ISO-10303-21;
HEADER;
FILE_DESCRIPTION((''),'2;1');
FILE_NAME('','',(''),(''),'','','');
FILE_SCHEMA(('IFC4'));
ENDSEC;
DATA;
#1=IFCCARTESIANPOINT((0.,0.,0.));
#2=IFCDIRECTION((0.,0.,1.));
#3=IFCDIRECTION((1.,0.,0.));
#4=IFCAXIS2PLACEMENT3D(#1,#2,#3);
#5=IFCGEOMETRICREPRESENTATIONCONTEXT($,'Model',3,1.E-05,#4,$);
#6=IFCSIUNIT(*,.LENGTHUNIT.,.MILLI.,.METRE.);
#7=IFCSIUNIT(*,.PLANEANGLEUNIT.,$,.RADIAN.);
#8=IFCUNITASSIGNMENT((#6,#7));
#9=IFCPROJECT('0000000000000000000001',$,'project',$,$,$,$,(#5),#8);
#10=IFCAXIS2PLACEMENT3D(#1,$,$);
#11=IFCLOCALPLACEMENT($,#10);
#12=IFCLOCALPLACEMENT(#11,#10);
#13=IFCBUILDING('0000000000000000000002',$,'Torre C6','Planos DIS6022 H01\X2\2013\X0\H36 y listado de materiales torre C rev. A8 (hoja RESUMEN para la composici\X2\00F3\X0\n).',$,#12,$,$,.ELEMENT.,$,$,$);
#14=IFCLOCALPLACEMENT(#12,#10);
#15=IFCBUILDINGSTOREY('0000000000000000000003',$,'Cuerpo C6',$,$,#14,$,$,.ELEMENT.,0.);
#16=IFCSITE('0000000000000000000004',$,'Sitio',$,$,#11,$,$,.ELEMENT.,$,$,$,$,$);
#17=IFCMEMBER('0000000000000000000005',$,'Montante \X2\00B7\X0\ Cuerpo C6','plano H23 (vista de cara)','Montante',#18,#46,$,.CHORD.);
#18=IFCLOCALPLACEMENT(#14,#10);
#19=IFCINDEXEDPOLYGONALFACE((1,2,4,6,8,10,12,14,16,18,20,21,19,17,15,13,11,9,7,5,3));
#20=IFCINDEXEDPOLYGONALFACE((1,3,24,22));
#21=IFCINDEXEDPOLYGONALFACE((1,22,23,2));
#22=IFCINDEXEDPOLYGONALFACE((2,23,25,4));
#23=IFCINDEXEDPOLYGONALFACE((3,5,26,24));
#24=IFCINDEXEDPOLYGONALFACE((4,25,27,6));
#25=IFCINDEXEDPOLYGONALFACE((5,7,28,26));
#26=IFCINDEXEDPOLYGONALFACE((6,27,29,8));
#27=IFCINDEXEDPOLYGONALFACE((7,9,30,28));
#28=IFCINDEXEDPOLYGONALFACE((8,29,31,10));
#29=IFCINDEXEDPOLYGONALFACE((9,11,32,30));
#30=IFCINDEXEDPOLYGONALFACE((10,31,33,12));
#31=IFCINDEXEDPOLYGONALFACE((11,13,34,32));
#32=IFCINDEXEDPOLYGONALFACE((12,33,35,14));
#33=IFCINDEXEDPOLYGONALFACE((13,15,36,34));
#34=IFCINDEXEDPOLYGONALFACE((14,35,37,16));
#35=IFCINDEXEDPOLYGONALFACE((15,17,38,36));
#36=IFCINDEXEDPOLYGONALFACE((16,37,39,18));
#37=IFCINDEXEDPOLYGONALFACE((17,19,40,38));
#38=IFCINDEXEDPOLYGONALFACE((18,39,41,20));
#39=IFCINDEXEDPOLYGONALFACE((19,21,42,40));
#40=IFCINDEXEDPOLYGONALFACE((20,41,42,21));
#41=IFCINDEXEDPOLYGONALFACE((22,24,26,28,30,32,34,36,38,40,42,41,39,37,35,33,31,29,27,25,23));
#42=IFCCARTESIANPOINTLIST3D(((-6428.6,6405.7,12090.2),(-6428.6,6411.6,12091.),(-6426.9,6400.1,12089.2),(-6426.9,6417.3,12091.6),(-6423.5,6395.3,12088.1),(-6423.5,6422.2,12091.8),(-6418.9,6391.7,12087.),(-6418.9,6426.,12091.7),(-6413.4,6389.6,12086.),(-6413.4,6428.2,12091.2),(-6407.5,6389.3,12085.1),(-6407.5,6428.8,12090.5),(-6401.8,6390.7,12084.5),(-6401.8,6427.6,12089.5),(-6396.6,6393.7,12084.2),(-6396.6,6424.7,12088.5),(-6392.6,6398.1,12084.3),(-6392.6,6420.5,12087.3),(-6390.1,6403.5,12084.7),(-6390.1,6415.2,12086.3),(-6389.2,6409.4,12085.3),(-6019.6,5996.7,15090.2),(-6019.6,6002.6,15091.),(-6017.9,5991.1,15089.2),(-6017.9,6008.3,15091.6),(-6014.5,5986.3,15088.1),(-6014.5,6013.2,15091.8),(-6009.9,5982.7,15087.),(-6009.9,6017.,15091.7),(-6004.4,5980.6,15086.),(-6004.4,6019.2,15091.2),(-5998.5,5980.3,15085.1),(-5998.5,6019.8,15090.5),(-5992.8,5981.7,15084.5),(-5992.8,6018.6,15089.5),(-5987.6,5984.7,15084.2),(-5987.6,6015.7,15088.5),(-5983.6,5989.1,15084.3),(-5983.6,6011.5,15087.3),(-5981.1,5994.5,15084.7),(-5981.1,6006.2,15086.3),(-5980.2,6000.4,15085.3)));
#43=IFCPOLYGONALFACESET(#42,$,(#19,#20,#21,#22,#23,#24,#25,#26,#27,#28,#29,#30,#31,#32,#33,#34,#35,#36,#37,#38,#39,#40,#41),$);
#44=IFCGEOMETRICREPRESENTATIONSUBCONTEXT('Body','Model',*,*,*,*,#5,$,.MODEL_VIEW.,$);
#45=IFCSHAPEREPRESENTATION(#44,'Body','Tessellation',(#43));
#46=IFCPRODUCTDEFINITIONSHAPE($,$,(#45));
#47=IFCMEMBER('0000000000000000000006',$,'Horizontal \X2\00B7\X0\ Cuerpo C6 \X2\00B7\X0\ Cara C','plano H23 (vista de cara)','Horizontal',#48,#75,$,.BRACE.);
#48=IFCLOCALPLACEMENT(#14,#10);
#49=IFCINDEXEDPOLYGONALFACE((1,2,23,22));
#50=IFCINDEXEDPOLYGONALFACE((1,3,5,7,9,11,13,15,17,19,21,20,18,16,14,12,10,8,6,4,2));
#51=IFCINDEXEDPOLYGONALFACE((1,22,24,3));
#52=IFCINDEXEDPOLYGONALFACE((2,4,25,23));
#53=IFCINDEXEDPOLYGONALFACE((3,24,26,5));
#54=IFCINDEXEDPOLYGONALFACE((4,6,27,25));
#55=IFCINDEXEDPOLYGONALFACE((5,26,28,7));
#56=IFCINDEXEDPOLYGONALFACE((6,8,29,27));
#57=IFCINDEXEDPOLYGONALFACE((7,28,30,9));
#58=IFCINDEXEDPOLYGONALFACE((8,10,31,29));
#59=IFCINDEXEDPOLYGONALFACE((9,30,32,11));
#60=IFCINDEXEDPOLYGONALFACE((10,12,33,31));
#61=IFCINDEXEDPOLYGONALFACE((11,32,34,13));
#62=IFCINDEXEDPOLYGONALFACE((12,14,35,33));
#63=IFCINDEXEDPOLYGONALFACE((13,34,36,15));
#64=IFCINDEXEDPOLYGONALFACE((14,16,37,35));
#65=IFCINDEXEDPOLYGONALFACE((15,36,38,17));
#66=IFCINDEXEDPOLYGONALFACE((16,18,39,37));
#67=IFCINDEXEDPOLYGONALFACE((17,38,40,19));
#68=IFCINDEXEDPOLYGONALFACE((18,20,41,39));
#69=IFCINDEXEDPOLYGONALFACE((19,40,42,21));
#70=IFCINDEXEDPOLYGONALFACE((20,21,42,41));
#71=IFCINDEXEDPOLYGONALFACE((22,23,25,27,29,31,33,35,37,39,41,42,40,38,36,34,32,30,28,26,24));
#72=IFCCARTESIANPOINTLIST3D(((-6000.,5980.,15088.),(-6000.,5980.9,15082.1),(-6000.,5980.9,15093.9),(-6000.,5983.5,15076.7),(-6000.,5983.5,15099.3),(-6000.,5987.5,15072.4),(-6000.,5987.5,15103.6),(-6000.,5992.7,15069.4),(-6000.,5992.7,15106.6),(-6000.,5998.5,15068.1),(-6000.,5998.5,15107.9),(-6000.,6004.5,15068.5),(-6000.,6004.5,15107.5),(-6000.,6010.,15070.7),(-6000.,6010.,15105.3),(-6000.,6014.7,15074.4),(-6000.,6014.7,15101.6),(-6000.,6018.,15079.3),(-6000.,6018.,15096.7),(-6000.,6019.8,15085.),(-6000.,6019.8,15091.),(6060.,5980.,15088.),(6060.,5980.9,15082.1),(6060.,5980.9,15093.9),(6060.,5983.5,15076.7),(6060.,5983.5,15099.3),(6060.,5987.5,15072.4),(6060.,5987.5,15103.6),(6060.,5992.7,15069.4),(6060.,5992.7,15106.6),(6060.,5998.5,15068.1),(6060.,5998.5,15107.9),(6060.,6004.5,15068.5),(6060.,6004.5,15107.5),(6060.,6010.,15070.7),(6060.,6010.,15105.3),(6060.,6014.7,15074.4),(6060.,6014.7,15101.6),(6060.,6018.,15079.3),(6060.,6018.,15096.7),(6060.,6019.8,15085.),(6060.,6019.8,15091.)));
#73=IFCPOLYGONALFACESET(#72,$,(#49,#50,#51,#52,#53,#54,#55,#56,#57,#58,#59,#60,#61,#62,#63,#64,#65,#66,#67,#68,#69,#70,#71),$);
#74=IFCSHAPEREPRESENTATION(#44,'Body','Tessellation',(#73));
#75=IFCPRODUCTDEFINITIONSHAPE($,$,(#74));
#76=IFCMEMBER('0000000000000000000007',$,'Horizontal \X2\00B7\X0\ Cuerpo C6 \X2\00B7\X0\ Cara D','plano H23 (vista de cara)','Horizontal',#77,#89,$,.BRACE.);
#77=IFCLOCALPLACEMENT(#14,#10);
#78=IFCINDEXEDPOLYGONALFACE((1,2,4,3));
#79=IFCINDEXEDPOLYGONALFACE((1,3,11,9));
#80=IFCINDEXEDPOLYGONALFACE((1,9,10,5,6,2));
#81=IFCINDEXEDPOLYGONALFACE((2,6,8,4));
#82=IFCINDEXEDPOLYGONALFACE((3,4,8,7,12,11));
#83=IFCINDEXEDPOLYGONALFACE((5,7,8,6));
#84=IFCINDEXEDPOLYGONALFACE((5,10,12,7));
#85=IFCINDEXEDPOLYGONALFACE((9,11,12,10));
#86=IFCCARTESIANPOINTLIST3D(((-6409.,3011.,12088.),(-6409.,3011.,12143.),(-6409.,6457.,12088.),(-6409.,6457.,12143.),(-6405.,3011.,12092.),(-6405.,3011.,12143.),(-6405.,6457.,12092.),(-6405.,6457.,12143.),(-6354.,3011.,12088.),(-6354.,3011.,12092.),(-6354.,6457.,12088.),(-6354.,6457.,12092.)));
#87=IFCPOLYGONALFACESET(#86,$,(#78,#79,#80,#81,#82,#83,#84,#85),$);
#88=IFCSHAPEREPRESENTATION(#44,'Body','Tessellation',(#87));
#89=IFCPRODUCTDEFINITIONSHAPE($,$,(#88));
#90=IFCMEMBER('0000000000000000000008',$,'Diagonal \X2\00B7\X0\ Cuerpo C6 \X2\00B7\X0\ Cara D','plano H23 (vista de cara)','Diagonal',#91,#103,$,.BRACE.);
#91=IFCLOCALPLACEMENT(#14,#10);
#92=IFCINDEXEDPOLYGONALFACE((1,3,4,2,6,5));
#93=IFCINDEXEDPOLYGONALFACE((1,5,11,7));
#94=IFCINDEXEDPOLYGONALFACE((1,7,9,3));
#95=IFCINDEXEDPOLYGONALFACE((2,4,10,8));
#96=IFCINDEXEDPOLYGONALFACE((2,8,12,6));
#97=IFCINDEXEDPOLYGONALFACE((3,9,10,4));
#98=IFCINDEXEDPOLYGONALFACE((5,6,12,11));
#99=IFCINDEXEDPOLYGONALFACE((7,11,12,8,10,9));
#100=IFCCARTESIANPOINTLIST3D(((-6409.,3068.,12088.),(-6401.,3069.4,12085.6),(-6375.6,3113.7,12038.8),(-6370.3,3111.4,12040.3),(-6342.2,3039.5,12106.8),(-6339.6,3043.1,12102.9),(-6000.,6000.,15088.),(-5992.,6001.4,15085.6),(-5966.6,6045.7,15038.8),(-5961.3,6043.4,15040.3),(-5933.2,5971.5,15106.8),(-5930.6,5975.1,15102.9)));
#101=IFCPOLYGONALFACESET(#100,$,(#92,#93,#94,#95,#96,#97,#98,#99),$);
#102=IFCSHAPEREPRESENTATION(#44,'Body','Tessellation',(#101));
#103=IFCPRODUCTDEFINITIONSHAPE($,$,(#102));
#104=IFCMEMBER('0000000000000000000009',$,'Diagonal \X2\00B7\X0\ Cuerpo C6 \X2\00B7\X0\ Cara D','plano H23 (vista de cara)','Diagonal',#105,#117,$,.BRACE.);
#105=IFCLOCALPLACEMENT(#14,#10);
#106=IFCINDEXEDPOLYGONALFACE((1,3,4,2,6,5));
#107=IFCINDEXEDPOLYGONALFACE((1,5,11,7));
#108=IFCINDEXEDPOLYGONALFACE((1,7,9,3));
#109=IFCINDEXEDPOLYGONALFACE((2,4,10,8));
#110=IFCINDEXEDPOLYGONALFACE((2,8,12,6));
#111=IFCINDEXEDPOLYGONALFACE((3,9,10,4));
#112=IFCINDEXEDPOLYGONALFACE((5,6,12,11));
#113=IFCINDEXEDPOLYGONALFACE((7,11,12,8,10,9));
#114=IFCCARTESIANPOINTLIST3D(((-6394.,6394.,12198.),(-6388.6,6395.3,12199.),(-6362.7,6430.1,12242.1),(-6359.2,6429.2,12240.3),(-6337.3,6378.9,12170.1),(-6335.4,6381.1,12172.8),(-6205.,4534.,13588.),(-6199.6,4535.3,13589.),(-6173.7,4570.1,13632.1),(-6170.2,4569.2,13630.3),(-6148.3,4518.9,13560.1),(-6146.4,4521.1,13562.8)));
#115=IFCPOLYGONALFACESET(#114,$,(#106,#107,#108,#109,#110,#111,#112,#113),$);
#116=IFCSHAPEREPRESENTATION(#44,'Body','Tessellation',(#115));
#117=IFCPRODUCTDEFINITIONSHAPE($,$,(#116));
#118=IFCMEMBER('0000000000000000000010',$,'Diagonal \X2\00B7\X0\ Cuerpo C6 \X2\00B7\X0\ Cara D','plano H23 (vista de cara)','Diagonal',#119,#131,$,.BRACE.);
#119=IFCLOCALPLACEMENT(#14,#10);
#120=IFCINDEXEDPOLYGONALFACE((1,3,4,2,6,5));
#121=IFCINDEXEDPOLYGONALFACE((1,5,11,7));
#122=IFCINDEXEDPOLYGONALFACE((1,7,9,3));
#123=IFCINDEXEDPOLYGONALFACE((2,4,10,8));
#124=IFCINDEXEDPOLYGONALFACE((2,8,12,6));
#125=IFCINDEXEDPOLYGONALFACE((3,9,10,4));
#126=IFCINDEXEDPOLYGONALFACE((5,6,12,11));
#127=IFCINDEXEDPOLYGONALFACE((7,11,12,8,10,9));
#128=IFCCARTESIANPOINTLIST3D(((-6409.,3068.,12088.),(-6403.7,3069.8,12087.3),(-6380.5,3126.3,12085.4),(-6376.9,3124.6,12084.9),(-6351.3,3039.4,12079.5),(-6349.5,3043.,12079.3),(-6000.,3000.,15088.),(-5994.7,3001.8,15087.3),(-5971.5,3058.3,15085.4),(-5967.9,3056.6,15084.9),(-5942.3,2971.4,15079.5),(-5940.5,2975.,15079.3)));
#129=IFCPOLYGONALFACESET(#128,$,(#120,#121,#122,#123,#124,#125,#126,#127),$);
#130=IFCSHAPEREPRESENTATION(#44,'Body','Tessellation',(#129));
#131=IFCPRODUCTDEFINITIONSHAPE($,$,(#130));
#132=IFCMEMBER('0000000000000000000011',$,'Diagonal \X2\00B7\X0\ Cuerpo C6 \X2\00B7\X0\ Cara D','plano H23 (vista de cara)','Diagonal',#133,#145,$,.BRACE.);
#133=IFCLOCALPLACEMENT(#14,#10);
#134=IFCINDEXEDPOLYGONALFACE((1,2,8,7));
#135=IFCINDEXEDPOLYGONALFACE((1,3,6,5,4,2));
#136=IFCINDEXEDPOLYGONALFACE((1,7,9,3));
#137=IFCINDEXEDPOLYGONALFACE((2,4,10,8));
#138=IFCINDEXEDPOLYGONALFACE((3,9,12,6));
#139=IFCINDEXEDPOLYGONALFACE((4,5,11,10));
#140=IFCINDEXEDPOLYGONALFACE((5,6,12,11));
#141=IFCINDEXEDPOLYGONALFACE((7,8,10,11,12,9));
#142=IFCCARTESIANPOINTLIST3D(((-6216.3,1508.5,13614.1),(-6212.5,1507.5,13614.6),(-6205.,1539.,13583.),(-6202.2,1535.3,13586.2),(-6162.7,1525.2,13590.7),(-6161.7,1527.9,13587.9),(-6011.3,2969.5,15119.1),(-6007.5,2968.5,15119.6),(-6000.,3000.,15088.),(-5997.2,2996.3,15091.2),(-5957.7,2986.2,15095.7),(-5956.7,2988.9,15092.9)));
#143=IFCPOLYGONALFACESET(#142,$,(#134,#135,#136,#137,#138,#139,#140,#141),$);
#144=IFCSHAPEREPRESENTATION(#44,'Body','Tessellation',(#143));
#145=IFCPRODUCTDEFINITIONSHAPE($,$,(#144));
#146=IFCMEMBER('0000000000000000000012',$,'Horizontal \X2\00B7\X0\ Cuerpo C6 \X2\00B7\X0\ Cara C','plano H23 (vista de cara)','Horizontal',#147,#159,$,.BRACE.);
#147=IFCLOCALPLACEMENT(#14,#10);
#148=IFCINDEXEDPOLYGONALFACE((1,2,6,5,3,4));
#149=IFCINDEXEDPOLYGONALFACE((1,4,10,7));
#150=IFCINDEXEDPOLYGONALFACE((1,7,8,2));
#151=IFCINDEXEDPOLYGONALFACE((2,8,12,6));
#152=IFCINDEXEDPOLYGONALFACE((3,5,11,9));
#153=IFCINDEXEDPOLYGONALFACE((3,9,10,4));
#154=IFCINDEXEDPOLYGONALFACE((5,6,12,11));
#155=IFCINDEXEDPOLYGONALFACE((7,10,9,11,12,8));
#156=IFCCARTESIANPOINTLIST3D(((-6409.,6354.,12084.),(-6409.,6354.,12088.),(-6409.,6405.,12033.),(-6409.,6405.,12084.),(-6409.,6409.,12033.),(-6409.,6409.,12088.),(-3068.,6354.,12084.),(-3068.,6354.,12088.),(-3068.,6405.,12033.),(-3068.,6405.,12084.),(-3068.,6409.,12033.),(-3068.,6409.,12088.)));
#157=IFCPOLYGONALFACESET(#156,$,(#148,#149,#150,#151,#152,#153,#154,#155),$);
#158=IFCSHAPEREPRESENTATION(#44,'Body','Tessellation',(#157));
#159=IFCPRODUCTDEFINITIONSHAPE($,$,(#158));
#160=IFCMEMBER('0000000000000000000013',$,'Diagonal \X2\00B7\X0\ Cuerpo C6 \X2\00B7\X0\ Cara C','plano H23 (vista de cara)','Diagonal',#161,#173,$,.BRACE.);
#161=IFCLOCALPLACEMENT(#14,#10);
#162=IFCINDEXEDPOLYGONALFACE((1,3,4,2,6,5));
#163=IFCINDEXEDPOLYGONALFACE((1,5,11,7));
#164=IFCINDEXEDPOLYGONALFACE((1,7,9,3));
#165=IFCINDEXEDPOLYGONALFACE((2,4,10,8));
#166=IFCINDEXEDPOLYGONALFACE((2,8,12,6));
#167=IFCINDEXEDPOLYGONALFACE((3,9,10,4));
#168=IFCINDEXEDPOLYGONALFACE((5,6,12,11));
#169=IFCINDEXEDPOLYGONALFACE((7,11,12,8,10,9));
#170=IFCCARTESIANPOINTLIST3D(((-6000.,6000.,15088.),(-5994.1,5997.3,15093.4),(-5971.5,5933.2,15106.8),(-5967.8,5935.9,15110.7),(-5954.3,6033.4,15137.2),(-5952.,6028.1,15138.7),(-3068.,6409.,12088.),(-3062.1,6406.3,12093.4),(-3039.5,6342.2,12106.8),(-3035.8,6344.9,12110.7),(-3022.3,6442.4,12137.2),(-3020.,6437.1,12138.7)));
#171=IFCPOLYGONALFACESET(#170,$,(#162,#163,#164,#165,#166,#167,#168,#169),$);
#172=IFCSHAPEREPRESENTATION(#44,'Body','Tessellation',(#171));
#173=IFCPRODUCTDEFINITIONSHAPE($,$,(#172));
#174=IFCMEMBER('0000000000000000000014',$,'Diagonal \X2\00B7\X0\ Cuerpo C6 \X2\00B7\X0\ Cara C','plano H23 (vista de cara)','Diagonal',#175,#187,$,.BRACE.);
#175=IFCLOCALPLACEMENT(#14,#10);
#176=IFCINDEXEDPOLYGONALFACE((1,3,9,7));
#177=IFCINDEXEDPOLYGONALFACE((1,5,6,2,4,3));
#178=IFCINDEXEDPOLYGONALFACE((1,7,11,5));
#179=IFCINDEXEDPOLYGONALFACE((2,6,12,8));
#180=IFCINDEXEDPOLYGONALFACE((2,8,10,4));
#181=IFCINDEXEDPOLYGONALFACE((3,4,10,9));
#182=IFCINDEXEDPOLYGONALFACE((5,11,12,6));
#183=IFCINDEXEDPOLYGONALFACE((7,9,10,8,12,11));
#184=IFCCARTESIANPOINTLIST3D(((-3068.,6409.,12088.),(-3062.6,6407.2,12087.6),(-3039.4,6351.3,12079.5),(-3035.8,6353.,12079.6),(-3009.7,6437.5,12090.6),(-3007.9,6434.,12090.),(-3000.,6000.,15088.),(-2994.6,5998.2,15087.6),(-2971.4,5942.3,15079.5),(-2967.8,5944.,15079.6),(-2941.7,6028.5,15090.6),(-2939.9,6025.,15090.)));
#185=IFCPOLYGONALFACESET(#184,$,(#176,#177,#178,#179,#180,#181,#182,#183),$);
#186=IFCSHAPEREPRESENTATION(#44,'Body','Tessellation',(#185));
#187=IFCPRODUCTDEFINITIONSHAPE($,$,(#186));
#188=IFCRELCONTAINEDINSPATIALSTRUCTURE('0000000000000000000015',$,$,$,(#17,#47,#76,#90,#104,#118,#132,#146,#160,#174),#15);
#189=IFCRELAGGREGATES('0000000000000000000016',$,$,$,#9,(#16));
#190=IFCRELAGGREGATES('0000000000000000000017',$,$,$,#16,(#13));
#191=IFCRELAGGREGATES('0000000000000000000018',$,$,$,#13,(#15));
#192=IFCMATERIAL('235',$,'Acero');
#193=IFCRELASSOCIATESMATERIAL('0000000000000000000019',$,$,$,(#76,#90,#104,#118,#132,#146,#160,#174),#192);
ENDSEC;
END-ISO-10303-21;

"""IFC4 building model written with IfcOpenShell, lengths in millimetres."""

from ifc_helpers import new_model, si_unit, frame, frame_2d, origin, origin_with_axes, place, context, subcontext, project, spatial, circle, l_section, extrude, material, element, save


model = new_model("IFC4")

# Units and contexts
model_context = context("Model", 3, precision=1e-05, world=origin_with_axes())
body_context = subcontext(model_context, "Body", "Model", "MODEL_VIEW")
ifc_project = project(units=[si_unit("LENGTHUNIT", "METRE", prefix="MILLI"), si_unit("PLANEANGLEUNIT", "RADIAN")], contexts=[model_context])

# Site, building, storey
site_placement = place(None, origin())
site = spatial("IfcSite", under=ifc_project, at=site_placement, Name="Sitio", CompositionType="ELEMENT")
building_placement = place(site_placement, origin())
building = spatial("IfcBuilding", under=site, at=building_placement, Name="Torre C6", Description="Planos DIS6022 H01–H36 y listado de materiales torre C rev. A8 (hoja RESUMEN para la composición).", CompositionType="ELEMENT")
storey_placement = place(building_placement, origin())
storey = spatial("IfcBuildingStorey", under=building, at=storey_placement, Name="Cuerpo C6", CompositionType="ELEMENT", Elevation=0.0)

# Members
member_1_placement = place(storey_placement, frame((-6000.0, 6000.0, 15088.0), z_axis=(-0.133868, 0.133868, -0.981916), x_axis=(0.990999, 0.018083, -0.132641)))
element("IfcMember", 1, at=member_1_placement, inside=storey, Name="Montante · Cuerpo C6", Description="plano H23 (vista de cara)", ObjectType="Montante", PredefinedType="CHORD", context=body_context, shape_type="SweptSolid", body=[
    extrude(circle(Radius=20.0), None, (0.0, 0.0, 1.0), 3055.3),
])
member_2_placement = place(storey_placement, frame((-6000.0, 6000.0, 15088.0), z_axis=(1.0, 0.0, 0.0), x_axis=(0.0, -1.0, 0.0)))
element("IfcMember", 2, at=member_2_placement, inside=storey, Name="Horizontal · Cuerpo C6 · Cara C", Description="plano H23 (vista de cara)", ObjectType="Horizontal", PredefinedType="BRACE", context=body_context, shape_type="SweptSolid", body=[
    extrude(circle(Radius=20.0), None, (0.0, 0.0, 1.0), 12060.0),
])
ifc_material_1 = material(Name="235", Category="Acero")
member_3_placement = place(storey_placement, frame((-6409.0, 6457.0, 12088.0), z_axis=(0.0, -1.0, 0.0), x_axis=(1.0, 0.0, 0.0)))
element("IfcMember", 3, at=member_3_placement, inside=storey, material=ifc_material_1, Name="Horizontal · Cuerpo C6 · Cara D", Description="plano H23 (vista de cara)", ObjectType="Horizontal", PredefinedType="BRACE", context=body_context, shape_type="SweptSolid", body=[
    extrude(l_section(Depth=55.0, Width=55.0, Thickness=4.0, at=frame_2d((27.5, 27.5))), None, (0.0, 0.0, 1.0), 3446.0),
])
member_4_placement = place(storey_placement, frame((-6409.0, 3068.0, 12088.0), z_axis=(0.097041, 0.695656, 0.71179), x_axis=(0.890141, -0.380587, 0.250605)))
element("IfcMember", 4, at=member_4_placement, inside=storey, material=ifc_material_1, Name="Diagonal · Cuerpo C6 · Cara D", Description="plano H23 (vista de cara)", ObjectType="Diagonal", PredefinedType="BRACE", context=body_context, shape_type="SweptSolid", body=[
    extrude(l_section(Depth=75.0, Width=75.0, Thickness=6.0, at=frame_2d((37.5, 37.5))), None, (0.0, 0.0, 1.0), 4214.7),
])
member_5_placement = place(storey_placement, frame((-6394.0, 6394.0, 12198.0), z_axis=(0.081127, -0.798392, 0.596648), x_axis=(0.872527, -0.23247, -0.429714)))
element("IfcMember", 5, at=member_5_placement, inside=storey, material=ifc_material_1, Name="Diagonal · Cuerpo C6 · Cara D", Description="plano H23 (vista de cara)", ObjectType="Diagonal", PredefinedType="BRACE", context=body_context, shape_type="SweptSolid", body=[
    extrude(l_section(Depth=65.0, Width=65.0, Thickness=4.0, at=frame_2d((32.5, 32.5))), None, (0.0, 0.0, 1.0), 2329.7),
])
member_6_placement = place(storey_placement, frame((-6409.0, 3068.0, 12088.0), z_axis=(0.13505, -0.022453, 0.990584), x_axis=(0.888305, -0.440149, -0.131082)))
element("IfcMember", 6, at=member_6_placement, inside=storey, material=ifc_material_1, Name="Diagonal · Cuerpo C6 · Cara D", Description="plano H23 (vista de cara)", ObjectType="Diagonal", PredefinedType="BRACE", context=body_context, shape_type="SweptSolid", body=[
    extrude(l_section(Depth=65.0, Width=65.0, Thickness=4.0, at=frame_2d((32.5, 32.5))), None, (0.0, 0.0, 1.0), 3028.5),
])
member_7_placement = place(storey_placement, frame((-6000.0, 3000.0, 15088.0), z_axis=(-0.097271, -0.693237, -0.714115), x_axis=(0.962882, -0.247072, 0.108692)))
element("IfcMember", 7, at=member_7_placement, inside=storey, material=ifc_material_1, Name="Diagonal · Cuerpo C6 · Cara D", Description="plano H23 (vista de cara)", ObjectType="Diagonal", PredefinedType="BRACE", context=body_context, shape_type="SweptSolid", body=[
    extrude(l_section(Depth=45.0, Width=45.0, Thickness=4.0, at=frame_2d((22.5, 22.5))), None, (0.0, 0.0, 1.0), 2107.5),
])
member_8_placement = place(storey_placement, frame((-6409.0, 6409.0, 12088.0), z_axis=(1.0, 0.0, 0.0), x_axis=(0.0, -1.0, 0.0)))
element("IfcMember", 8, at=member_8_placement, inside=storey, material=ifc_material_1, Name="Horizontal · Cuerpo C6 · Cara C", Description="plano H23 (vista de cara)", ObjectType="Horizontal", PredefinedType="BRACE", context=body_context, shape_type="SweptSolid", body=[
    extrude(l_section(Depth=55.0, Width=55.0, Thickness=4.0, at=frame_2d((27.5, 27.5))), None, (0.0, 0.0, 1.0), 3341.0),
])
member_9_placement = place(storey_placement, frame((-3068.0, 6409.0, 12088.0), z_axis=(-0.695656, -0.097041, 0.71179), x_axis=(0.380587, -0.890141, 0.250605)))
element("IfcMember", 9, at=member_9_placement, inside=storey, material=ifc_material_1, Name="Diagonal · Cuerpo C6 · Cara C", Description="plano H23 (vista de cara)", ObjectType="Diagonal", PredefinedType="BRACE", context=body_context, shape_type="SweptSolid", body=[
    extrude(l_section(Depth=75.0, Width=75.0, Thickness=6.0, at=frame_2d((37.5, 37.5))), None, (0.0, 0.0, 1.0), 4214.7),
])
member_10_placement = place(storey_placement, frame((-3068.0, 6409.0, 12088.0), z_axis=(0.022453, -0.13505, 0.990584), x_axis=(0.440149, -0.888305, -0.131082)))
element("IfcMember", 10, at=member_10_placement, inside=storey, material=ifc_material_1, Name="Diagonal · Cuerpo C6 · Cara C", Description="plano H23 (vista de cara)", ObjectType="Diagonal", PredefinedType="BRACE", context=body_context, shape_type="SweptSolid", body=[
    extrude(l_section(Depth=65.0, Width=65.0, Thickness=4.0, at=frame_2d((32.5, 32.5))), None, (0.0, 0.0, 1.0), 3028.5),
])

save(model, "model.ifc")
